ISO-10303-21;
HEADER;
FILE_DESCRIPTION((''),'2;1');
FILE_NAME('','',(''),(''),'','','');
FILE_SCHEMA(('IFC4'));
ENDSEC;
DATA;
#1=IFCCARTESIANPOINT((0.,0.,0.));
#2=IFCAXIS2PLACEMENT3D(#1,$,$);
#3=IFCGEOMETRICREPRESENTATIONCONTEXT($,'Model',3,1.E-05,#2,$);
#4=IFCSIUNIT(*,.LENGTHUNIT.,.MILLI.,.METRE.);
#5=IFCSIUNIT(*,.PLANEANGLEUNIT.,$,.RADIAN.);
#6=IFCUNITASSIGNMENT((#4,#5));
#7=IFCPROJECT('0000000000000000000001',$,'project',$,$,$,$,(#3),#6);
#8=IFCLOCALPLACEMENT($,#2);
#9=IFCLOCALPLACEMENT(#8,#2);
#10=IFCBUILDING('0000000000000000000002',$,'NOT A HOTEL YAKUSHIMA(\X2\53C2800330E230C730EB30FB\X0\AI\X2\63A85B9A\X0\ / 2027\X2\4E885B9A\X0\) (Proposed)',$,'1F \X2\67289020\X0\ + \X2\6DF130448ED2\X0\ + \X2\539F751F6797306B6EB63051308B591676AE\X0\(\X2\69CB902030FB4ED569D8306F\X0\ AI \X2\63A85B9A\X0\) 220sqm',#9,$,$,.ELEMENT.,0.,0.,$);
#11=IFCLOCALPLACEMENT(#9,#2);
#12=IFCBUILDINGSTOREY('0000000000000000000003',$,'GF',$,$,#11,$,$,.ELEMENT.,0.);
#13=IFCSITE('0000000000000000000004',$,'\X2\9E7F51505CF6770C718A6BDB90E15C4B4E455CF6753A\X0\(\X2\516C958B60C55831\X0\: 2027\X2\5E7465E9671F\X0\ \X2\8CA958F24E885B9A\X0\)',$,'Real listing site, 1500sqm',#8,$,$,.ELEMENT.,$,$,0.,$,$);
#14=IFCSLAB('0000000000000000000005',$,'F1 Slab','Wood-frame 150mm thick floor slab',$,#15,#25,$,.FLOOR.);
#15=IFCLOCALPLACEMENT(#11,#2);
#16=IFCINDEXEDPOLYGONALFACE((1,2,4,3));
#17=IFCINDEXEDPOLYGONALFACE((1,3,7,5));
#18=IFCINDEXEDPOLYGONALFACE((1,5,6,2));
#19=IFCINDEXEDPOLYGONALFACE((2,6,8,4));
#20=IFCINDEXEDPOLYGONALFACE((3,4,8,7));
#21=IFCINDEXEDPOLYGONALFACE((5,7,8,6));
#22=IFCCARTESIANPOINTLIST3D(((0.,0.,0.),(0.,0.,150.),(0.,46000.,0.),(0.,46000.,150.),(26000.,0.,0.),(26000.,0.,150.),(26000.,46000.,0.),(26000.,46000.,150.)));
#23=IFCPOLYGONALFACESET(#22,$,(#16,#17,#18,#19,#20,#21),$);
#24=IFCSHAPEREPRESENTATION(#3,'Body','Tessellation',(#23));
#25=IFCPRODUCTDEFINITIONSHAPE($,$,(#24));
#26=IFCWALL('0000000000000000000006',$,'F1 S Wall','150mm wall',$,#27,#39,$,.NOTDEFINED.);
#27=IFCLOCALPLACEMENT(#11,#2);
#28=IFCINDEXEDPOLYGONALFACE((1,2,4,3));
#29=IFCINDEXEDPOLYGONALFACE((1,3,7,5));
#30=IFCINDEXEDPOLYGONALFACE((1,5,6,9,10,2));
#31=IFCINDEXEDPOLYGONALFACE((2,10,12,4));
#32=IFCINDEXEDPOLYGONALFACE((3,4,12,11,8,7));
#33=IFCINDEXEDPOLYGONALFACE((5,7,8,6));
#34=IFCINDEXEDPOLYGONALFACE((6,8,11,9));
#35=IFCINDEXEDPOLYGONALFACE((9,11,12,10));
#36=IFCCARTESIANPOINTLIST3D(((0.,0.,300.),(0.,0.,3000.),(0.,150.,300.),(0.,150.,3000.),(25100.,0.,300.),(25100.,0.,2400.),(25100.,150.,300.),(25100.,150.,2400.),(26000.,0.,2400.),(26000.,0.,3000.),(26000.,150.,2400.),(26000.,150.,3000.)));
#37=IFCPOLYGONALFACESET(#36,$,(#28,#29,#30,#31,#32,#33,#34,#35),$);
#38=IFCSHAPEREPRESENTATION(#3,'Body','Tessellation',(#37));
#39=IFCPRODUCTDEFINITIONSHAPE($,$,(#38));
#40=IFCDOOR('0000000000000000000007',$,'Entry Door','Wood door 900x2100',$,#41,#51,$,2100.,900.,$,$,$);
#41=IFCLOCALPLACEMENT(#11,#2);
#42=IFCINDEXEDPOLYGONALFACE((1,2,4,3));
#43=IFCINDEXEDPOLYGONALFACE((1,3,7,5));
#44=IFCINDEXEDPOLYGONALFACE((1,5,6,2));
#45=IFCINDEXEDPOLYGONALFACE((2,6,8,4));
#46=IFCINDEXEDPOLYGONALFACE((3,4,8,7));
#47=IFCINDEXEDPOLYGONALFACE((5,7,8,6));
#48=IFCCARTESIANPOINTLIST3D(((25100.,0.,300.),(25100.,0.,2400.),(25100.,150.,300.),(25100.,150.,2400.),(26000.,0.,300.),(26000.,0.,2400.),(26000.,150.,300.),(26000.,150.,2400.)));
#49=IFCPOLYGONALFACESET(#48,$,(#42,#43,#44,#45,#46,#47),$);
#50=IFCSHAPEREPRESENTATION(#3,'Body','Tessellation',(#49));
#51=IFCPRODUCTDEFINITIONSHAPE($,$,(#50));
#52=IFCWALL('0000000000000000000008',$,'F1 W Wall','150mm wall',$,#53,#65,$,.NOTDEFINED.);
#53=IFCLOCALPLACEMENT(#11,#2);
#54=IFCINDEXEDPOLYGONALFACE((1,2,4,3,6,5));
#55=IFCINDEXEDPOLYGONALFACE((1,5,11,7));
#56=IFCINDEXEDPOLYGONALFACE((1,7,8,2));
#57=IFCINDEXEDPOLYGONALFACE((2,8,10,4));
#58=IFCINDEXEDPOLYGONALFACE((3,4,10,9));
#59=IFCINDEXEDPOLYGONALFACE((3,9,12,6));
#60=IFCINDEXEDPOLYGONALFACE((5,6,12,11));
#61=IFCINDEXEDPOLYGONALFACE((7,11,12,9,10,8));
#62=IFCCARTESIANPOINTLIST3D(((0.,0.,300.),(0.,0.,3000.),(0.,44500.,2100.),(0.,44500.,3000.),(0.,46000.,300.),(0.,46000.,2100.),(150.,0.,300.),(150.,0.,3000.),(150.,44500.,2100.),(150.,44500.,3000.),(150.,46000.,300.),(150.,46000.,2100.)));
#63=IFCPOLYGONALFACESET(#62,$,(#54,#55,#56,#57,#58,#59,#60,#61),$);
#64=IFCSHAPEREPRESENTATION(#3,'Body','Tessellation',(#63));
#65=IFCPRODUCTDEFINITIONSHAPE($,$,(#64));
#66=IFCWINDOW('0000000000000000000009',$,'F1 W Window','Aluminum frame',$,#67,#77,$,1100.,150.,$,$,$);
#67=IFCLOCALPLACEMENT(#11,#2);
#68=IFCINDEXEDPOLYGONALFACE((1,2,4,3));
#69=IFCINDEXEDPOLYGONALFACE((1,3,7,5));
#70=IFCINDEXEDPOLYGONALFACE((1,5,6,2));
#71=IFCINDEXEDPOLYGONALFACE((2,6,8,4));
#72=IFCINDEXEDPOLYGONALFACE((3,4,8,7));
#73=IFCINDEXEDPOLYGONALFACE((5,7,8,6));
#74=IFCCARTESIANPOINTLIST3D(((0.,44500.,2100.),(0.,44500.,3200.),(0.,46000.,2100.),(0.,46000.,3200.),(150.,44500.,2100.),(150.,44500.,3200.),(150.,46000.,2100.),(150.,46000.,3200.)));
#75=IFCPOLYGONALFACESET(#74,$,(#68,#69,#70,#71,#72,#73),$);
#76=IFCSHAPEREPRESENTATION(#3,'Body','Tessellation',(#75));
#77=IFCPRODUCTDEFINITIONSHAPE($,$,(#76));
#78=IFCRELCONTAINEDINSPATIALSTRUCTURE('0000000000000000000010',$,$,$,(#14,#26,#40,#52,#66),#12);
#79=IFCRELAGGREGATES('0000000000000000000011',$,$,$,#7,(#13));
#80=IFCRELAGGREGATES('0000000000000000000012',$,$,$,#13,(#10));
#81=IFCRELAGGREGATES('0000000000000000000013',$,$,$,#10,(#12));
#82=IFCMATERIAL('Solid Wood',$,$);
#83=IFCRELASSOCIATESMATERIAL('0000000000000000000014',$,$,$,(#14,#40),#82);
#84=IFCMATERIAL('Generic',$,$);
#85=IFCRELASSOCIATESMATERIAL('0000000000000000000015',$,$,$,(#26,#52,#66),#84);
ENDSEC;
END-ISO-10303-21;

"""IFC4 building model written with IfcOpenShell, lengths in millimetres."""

from ifc_helpers import new_model, si_unit, frame, frame_2d, origin, place, context, project, spatial, rectangle, extrude, material, element, fill, save


model = new_model("IFC4")

# Units and contexts
model_context = context("Model", 3, precision=1e-05, world=origin())
ifc_project = project(units=[si_unit("LENGTHUNIT", "METRE", prefix="MILLI"), si_unit("PLANEANGLEUNIT", "RADIAN")], contexts=[model_context])

# Site, building, storey
site_placement = place(None, origin())
site = spatial("IfcSite", under=ifc_project, at=site_placement, Name="鹿児島県熊毛郡屋久島町(公開情報: 2027年早期 販売予定)", ObjectType="Real listing site, 1500sqm", CompositionType="ELEMENT", RefElevation=0.0)
building_placement = place(site_placement, origin())
building = spatial("IfcBuilding", under=site, at=building_placement, Name="NOT A HOTEL YAKUSHIMA(参考モデル・AI推定 / 2027予定) (Proposed)", ObjectType="1F 木造 + 深い軒 + 原生林に溶ける外皮(構造・仕様は AI 推定) 220sqm", CompositionType="ELEMENT", ElevationOfRefHeight=0.0, ElevationOfTerrain=0.0)
storey_placement = place(building_placement, origin())
storey = spatial("IfcBuildingStorey", under=building, at=storey_placement, Name="GF", CompositionType="ELEMENT", Elevation=0.0)

# Slab
ifc_material_1 = material(Name="Solid Wood")
slab_placement = place(storey_placement, origin())
element("IfcSlab", 1, at=slab_placement, inside=storey, material=ifc_material_1, Name="F1 Slab", Description="Wood-frame 150mm thick floor slab", PredefinedType="FLOOR", context=model_context, shape_type="SweptSolid", body=[
    extrude(rectangle(XDim=26000.0, YDim=46000.0, at=frame_2d((13000.0, 23000.0))), origin(), (0.0, 0.0, 1.0), 150.0),
])

# Shared definitions
ifc_material_2 = material(Name="Generic")

# Wall, opening, door
wall_1_placement = place(storey_placement, frame((0.0, 0.0, 150.0)))
wall_1 = element("IfcWall", 2, at=wall_1_placement, inside=storey, material=ifc_material_2, Name="F1 S Wall", Description="150mm wall", PredefinedType="NOTDEFINED", context=model_context, shape_type="SweptSolid", body=[
    extrude(rectangle(XDim=26000.0, YDim=150.0, at=frame_2d((13000.0, 75.0))), frame((0.0, 0.0, 150.0)), (0.0, 0.0, 1.0), 2700.0),
])
opening_1_placement = place(storey_placement, frame((12550.0, 0.0, 150.0)))
opening_1 = element("IfcOpeningElement", 3, at=opening_1_placement, cuts=wall_1, PredefinedType="NOTDEFINED", context=model_context, shape_type="SweptSolid", body=[
    extrude(rectangle(XDim=900.0, YDim=150.0, at=frame_2d((450.0, 75.0))), frame((12550.0, 0.0, 150.0)), (0.0, 0.0, 1.0), 2100.0),
])
door_placement = place(storey_placement, frame((12550.0, 0.0, 150.0)))
door = element("IfcDoor", 4, at=door_placement, inside=storey, material=ifc_material_1, Name="Entry Door", Description="Wood door 900x2100", OverallHeight=2100.0, OverallWidth=900.0, context=model_context, shape_type="SweptSolid", body=[
    extrude(rectangle(XDim=900.0, YDim=150.0, at=frame_2d((450.0, 75.0))), frame((12550.0, 0.0, 150.0)), (0.0, 0.0, 1.0), 2100.0),
])
fill(opening_1, door)

# Wall, opening, window
wall_2_placement = place(storey_placement, frame((0.0, 0.0, 150.0)))
wall_2 = element("IfcWall", 5, at=wall_2_placement, inside=storey, material=ifc_material_2, Name="F1 W Wall", Description="150mm wall", PredefinedType="NOTDEFINED", context=model_context, shape_type="SweptSolid", body=[
    extrude(rectangle(XDim=150.0, YDim=46000.0, at=frame_2d((75.0, 23000.0))), frame((0.0, 0.0, 150.0)), (0.0, 0.0, 1.0), 2700.0),
])
opening_2_placement = place(storey_placement, frame((0.0, 22250.0, 1050.0)))
opening_2 = element("IfcOpeningElement", 6, at=opening_2_placement, cuts=wall_2, PredefinedType="NOTDEFINED", context=model_context, shape_type="SweptSolid", body=[
    extrude(rectangle(XDim=150.0, YDim=1500.0, at=frame_2d((75.0, 750.0))), frame((0.0, 22250.0, 1050.0)), (0.0, 0.0, 1.0), 1100.0),
])
window_1_placement = place(storey_placement, frame((0.0, 22250.0, 1050.0)))
window_1 = element("IfcWindow", 7, at=window_1_placement, inside=storey, material=ifc_material_2, Name="F1 W Window", Description="Aluminum frame", OverallHeight=1100.0, OverallWidth=150.0, context=model_context, shape_type="SweptSolid", body=[
    extrude(rectangle(XDim=150.0, YDim=1500.0, at=frame_2d((75.0, 750.0))), frame((0.0, 22250.0, 1050.0)), (0.0, 0.0, 1.0), 1100.0),
])
fill(opening_2, window_1)

save(model, "model.ifc")
